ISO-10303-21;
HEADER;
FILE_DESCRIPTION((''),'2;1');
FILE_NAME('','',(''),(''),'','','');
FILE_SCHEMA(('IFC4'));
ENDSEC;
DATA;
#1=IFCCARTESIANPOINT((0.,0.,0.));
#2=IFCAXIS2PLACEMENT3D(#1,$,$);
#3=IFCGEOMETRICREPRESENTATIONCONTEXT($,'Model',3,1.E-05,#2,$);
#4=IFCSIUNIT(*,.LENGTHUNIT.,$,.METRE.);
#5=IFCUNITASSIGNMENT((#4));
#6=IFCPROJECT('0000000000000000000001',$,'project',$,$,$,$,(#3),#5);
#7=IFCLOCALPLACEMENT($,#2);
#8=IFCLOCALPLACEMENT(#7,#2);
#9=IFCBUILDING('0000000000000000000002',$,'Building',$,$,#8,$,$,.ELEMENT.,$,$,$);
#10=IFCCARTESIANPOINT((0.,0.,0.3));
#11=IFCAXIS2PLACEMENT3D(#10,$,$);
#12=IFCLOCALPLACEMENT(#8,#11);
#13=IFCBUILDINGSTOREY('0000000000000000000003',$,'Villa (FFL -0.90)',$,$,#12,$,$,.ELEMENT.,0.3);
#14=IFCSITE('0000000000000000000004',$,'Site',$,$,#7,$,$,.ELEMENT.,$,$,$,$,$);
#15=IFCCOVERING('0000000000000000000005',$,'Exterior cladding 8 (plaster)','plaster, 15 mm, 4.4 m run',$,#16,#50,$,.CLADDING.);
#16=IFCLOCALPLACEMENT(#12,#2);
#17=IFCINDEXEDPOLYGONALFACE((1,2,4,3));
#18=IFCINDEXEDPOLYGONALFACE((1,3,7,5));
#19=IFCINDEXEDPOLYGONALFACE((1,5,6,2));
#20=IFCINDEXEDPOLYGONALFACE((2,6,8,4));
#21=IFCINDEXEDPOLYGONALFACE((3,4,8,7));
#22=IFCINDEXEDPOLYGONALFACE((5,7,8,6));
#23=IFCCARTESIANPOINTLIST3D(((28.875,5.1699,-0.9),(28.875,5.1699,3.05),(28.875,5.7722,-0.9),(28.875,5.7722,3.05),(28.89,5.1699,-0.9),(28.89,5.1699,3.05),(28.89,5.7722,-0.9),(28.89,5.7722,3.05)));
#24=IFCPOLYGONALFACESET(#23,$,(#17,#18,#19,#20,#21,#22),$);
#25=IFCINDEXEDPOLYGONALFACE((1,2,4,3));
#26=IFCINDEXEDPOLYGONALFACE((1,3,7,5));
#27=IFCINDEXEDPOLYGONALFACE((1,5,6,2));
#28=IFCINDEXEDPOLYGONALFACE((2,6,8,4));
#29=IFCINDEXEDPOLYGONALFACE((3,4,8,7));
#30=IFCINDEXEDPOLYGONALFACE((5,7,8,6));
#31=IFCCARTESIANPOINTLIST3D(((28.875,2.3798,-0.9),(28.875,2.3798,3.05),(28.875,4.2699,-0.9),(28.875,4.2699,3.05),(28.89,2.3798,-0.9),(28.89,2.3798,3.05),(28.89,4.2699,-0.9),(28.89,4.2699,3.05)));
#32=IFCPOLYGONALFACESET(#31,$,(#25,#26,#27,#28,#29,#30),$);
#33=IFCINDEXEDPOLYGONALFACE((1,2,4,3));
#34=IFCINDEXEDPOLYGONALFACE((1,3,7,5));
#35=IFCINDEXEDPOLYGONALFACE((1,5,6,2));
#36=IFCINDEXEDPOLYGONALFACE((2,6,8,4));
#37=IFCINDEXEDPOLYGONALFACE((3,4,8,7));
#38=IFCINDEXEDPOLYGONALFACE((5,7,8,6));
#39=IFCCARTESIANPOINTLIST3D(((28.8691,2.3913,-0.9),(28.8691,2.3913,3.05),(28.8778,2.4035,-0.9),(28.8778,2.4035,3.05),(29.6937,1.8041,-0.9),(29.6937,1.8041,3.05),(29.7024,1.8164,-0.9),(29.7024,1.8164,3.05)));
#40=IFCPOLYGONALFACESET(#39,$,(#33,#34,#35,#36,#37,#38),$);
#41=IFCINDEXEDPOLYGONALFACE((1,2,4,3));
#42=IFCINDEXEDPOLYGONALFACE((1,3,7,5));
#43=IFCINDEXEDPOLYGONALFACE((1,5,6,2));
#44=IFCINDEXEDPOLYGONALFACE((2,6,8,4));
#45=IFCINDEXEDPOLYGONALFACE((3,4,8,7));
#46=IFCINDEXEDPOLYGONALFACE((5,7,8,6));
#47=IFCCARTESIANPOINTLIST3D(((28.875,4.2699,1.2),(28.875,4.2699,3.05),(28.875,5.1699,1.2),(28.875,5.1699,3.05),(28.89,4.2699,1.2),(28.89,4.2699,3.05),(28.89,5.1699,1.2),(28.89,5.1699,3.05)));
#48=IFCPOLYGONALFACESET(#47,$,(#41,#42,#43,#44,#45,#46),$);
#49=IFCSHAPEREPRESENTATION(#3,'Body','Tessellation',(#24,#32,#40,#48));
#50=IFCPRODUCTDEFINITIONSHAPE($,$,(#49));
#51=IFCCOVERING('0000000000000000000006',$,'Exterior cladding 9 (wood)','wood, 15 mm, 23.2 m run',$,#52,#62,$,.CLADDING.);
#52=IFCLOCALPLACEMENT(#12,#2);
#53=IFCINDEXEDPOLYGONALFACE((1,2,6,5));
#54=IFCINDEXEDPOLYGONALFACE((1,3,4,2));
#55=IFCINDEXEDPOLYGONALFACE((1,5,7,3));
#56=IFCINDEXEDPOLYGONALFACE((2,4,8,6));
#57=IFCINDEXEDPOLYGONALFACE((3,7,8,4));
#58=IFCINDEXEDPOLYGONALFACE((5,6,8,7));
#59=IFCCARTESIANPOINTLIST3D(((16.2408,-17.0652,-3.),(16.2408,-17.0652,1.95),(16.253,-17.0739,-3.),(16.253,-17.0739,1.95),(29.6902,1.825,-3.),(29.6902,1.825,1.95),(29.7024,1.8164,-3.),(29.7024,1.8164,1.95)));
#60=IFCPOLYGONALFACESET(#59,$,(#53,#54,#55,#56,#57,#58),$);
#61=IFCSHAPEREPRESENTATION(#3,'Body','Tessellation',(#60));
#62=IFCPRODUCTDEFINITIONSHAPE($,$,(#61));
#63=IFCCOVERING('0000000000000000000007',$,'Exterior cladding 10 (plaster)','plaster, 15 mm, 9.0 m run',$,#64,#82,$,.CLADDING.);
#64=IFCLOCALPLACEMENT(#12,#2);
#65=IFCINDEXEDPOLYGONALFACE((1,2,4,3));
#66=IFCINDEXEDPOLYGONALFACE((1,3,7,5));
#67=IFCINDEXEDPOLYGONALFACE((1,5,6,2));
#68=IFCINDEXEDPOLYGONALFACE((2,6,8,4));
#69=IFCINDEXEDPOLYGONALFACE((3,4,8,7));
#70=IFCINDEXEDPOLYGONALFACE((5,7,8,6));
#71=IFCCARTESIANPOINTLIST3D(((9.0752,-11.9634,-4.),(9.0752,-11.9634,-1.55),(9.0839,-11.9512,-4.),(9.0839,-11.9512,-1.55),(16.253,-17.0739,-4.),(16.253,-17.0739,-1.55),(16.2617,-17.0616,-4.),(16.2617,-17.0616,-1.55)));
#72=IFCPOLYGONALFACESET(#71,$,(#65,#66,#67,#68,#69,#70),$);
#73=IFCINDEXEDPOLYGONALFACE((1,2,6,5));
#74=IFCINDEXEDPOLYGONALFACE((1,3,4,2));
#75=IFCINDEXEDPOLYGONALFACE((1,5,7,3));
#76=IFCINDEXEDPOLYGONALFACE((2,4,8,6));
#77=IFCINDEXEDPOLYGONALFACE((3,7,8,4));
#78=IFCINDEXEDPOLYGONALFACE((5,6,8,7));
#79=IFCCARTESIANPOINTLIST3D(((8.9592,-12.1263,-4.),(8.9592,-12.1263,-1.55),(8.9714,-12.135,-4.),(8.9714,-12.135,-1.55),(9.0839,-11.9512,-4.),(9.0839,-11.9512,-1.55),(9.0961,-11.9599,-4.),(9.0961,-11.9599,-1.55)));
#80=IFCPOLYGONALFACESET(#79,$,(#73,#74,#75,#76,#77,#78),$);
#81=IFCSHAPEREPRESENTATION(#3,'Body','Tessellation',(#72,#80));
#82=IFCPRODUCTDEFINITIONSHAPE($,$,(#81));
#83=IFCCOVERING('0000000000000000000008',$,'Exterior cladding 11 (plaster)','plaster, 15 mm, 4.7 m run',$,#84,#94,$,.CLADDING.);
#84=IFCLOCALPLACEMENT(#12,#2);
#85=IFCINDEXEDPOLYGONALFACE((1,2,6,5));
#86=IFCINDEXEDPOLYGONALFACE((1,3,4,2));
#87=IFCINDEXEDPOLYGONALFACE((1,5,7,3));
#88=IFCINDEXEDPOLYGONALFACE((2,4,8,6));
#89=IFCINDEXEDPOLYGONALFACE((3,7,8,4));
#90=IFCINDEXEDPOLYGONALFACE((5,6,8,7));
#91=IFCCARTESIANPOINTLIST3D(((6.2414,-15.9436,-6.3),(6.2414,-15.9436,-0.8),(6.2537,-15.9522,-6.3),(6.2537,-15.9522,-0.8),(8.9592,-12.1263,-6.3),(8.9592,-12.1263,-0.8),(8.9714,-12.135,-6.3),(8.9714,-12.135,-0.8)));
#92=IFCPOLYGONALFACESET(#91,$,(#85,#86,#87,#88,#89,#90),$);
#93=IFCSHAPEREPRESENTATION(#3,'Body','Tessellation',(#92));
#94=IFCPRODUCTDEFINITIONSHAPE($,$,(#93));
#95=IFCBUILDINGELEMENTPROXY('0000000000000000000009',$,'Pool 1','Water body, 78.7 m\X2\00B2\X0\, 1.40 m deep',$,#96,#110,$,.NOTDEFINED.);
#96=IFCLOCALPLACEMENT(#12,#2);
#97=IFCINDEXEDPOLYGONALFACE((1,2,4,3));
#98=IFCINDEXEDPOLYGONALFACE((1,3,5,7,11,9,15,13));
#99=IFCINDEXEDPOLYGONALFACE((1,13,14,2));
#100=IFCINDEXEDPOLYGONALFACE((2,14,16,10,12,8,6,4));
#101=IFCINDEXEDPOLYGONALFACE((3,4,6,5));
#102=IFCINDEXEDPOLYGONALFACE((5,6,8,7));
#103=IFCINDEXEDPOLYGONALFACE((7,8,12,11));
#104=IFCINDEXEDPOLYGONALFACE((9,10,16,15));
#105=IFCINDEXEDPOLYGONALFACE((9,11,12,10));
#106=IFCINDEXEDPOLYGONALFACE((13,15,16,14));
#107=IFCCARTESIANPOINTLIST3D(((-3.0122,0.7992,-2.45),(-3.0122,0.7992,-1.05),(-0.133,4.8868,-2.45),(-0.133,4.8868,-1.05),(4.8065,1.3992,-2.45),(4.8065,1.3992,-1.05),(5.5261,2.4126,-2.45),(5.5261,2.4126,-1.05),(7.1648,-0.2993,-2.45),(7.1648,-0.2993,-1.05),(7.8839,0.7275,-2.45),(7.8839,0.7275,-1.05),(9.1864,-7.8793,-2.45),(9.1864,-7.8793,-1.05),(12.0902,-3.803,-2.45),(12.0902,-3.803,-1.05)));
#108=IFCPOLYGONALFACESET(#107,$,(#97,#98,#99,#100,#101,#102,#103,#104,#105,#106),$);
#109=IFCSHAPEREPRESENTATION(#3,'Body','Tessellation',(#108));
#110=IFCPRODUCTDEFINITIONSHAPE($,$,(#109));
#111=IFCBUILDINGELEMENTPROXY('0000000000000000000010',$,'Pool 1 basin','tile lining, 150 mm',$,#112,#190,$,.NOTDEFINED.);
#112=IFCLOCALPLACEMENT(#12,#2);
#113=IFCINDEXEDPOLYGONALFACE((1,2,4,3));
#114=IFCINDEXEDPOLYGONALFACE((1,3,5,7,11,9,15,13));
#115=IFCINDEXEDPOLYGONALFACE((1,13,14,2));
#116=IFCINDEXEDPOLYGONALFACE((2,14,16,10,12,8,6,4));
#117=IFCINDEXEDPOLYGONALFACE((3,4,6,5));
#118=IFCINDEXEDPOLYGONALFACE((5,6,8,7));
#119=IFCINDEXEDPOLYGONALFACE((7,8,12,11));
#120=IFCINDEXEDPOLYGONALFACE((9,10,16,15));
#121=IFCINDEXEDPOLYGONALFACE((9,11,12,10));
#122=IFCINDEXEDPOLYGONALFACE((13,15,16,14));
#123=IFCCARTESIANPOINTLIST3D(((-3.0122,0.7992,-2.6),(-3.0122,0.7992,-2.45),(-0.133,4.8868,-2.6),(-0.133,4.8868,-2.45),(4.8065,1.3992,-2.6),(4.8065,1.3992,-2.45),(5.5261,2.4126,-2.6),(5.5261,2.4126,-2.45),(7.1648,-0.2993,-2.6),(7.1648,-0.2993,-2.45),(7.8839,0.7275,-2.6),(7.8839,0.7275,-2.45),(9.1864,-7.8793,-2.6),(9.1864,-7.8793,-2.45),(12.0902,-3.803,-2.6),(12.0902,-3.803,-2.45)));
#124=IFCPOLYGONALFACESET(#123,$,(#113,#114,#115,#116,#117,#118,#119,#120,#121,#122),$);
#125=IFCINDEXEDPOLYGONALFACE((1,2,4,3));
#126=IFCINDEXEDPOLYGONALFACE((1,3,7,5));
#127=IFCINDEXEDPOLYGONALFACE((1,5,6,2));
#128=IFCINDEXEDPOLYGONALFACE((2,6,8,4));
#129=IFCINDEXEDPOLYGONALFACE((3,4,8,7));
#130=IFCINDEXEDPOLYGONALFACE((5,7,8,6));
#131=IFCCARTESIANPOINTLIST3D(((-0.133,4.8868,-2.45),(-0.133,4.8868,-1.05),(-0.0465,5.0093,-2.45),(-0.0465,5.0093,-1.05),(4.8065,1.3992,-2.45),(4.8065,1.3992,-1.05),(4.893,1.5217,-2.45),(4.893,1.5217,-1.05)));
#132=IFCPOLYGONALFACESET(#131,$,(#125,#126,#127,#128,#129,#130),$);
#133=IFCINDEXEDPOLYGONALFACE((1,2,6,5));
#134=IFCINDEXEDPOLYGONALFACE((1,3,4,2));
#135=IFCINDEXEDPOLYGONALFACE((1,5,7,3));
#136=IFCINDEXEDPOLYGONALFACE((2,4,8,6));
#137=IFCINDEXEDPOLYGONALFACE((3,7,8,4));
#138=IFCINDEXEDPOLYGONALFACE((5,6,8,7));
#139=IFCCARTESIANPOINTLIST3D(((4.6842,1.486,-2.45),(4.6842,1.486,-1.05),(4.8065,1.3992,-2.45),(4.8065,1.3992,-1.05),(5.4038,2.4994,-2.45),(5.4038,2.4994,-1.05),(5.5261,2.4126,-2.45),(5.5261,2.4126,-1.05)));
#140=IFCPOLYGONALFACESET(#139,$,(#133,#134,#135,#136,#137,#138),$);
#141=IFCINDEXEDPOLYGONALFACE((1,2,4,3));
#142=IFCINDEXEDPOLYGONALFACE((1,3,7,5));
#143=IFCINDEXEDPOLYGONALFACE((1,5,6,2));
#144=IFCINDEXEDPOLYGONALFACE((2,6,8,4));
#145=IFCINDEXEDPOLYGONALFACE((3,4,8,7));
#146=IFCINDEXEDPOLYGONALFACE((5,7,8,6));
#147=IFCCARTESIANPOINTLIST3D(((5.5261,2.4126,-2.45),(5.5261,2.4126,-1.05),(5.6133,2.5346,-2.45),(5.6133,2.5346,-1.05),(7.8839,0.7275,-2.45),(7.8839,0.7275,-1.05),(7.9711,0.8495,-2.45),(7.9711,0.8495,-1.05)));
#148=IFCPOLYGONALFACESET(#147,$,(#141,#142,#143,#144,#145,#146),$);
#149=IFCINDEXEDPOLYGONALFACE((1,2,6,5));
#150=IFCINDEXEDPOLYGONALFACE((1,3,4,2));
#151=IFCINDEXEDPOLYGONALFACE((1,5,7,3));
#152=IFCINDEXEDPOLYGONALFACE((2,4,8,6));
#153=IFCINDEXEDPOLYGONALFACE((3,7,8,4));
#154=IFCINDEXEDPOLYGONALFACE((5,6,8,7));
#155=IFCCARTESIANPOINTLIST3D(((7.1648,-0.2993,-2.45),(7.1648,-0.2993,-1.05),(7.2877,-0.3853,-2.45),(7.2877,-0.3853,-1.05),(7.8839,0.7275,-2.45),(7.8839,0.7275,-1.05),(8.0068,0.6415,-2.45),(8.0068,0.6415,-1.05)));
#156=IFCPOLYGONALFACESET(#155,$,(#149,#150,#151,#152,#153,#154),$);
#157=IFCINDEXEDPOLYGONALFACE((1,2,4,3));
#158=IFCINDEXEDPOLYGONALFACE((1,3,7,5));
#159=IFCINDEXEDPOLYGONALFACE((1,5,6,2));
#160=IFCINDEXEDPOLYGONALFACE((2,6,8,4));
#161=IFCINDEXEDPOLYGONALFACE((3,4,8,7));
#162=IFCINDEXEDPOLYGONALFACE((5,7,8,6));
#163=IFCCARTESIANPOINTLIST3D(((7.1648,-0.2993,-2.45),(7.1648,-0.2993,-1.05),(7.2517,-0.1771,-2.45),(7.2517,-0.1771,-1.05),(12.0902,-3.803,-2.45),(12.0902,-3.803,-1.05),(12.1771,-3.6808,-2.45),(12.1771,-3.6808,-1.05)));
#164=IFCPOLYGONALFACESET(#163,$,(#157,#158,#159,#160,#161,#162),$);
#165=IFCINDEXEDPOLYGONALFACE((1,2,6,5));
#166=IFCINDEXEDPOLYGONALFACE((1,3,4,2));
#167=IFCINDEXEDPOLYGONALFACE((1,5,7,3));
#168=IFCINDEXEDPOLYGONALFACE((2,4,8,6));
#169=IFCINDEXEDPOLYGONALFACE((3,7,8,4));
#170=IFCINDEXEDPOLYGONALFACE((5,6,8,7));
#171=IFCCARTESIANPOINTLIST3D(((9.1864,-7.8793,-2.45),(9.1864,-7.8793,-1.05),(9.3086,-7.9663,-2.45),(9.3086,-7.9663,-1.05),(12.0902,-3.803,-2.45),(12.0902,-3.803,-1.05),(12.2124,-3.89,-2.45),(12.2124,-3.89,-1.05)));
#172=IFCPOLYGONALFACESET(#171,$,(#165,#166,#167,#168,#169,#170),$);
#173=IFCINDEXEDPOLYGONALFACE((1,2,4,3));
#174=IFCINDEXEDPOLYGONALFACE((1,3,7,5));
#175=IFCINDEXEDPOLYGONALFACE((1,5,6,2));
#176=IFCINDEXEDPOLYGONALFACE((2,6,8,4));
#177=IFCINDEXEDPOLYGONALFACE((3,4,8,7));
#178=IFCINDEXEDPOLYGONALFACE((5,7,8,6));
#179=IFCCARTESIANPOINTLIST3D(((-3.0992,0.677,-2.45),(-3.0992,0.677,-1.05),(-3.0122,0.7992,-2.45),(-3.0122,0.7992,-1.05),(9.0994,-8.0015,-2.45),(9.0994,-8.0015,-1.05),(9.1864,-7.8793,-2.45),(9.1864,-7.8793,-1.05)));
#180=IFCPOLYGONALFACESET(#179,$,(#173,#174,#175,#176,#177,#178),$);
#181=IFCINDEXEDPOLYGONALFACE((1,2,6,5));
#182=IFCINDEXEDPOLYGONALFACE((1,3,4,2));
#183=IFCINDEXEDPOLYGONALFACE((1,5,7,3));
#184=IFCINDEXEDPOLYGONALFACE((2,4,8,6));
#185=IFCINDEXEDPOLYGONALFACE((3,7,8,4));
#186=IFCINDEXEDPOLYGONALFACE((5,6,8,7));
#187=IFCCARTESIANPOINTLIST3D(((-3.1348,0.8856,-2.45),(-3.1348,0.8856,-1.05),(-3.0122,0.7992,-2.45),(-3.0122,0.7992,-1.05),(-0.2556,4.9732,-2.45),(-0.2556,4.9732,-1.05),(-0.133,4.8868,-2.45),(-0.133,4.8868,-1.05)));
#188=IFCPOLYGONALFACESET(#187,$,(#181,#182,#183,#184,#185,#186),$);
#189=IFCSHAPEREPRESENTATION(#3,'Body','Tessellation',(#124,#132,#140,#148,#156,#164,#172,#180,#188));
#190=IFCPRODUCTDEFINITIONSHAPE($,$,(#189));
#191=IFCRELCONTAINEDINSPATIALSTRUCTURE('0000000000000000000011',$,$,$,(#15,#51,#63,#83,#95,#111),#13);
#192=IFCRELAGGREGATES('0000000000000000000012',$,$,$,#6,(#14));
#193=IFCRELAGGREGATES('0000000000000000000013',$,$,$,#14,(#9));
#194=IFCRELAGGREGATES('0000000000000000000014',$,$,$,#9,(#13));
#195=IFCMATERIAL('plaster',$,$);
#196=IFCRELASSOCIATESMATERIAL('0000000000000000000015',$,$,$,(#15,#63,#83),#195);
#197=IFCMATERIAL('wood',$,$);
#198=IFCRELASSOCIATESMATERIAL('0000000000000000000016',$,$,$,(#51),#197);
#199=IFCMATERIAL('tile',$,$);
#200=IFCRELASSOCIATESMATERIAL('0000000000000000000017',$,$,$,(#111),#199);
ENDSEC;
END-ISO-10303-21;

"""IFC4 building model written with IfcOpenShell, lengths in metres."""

from ifc_helpers import new_model, si_unit, frame, origin, origin_with_axes, place, context, project, spatial, polyline, outline, extrude, material, element, save


model = new_model("IFC4")

# Units and contexts
model_context = context("Model", 3, precision=1e-05, world=origin())
ifc_project = project(units=[si_unit("LENGTHUNIT", "METRE")], contexts=[model_context])

# Site, building, storey
site_placement = place(None, origin())
site = spatial("IfcSite", under=ifc_project, at=site_placement, Name="Site", CompositionType="ELEMENT")
building_placement = place(site_placement, origin())
building = spatial("IfcBuilding", under=site, at=building_placement, Name="Building", CompositionType="ELEMENT")
storey_placement = place(building_placement, frame((0.0, 0.0, 0.3)))
storey = spatial("IfcBuildingStorey", under=building, at=storey_placement, Name="Villa (FFL -0.90)", CompositionType="ELEMENT", Elevation=0.3)

# Coverings
ifc_material_1 = material(Name="plaster")
covering_1_placement = place(storey_placement, origin_with_axes())
element("IfcCovering", 1, at=covering_1_placement, inside=storey, material=ifc_material_1, Name="Exterior cladding 8 (plaster)", Description="plaster, 15 mm, 4.4 m run", PredefinedType="CLADDING", context=model_context, shape_type="SweptSolid", body=[
    extrude(outline(polyline([(28.875, 5.7721), (28.875, 5.1699), (28.89, 5.1699), (28.89, 5.7721), (28.875, 5.7721)])), frame((0.0, 0.0, -0.9)), (0.0, 0.0, 1.0), 3.95),
    extrude(outline(polyline([(28.875, 4.2699), (28.875, 2.3798), (28.89, 2.3798), (28.89, 4.2699), (28.875, 4.2699)])), frame((0.0, 0.0, -0.9)), (0.0, 0.0, 1.0), 3.95),
    extrude(outline(polyline([(28.8691, 2.3913), (29.6937, 1.8041), (29.7024, 1.8163), (28.8778, 2.4035), (28.8691, 2.3913)])), frame((0.0, 0.0, -0.9)), (0.0, 0.0, 1.0), 3.95),
    extrude(outline(polyline([(28.875, 5.1699), (28.875, 4.2699), (28.89, 4.2699), (28.89, 5.1699), (28.875, 5.1699)])), frame((0.0, 0.0, 1.2)), (0.0, 0.0, 1.0), 1.85),
])
ifc_material_2 = material(Name="wood")
covering_2_placement = place(storey_placement, origin_with_axes())
element("IfcCovering", 2, at=covering_2_placement, inside=storey, material=ifc_material_2, Name="Exterior cladding 9 (wood)", Description="wood, 15 mm, 23.2 m run", PredefinedType="CLADDING", context=model_context, shape_type="SweptSolid", body=[
    extrude(outline(polyline([(29.6902, 1.8251), (16.2408, -17.0652), (16.253, -17.0739), (29.7024, 1.8163), (29.6902, 1.8251)])), frame((0.0, 0.0, -3.0)), (0.0, 0.0, 1.0), 4.95),
])
covering_3_placement = place(storey_placement, origin_with_axes())
element("IfcCovering", 3, at=covering_3_placement, inside=storey, material=ifc_material_1, Name="Exterior cladding 10 (plaster)", Description="plaster, 15 mm, 9.0 m run", PredefinedType="CLADDING", context=model_context, shape_type="SweptSolid", body=[
    extrude(outline(polyline([(16.2617, -17.0616), (9.0839, -11.9512), (9.0752, -11.9634), (16.253, -17.0739), (16.2617, -17.0616)])), frame((0.0, 0.0, -4.0)), (0.0, 0.0, 1.0), 2.45),
    extrude(outline(polyline([(9.0839, -11.9512), (8.9592, -12.1263), (8.9714, -12.135), (9.0961, -11.9599), (9.0839, -11.9512)])), frame((0.0, 0.0, -4.0)), (0.0, 0.0, 1.0), 2.45),
])
covering_4_placement = place(storey_placement, origin_with_axes())
element("IfcCovering", 4, at=covering_4_placement, inside=storey, material=ifc_material_1, Name="Exterior cladding 11 (plaster)", Description="plaster, 15 mm, 4.7 m run", PredefinedType="CLADDING", context=model_context, shape_type="SweptSolid", body=[
    extrude(outline(polyline([(8.9592, -12.1263), (6.2414, -15.9436), (6.2537, -15.9522), (8.9714, -12.135), (8.9592, -12.1263)])), frame((0.0, 0.0, -6.3)), (0.0, 0.0, 1.0), 5.5),
])

# Building element proxies
placement = place(storey_placement, origin_with_axes())
element("IfcBuildingElementProxy", 5, at=placement, inside=storey, Name="Pool 1", Description="Water body, 78.7 m², 1.40 m deep", PredefinedType="NOTDEFINED", context=model_context, shape_type="SweptSolid", body=[
    extrude(outline(polyline([(-0.133, 4.8868), (4.8065, 1.3992), (5.5261, 2.4126), (7.8839, 0.7275), (7.1648, -0.2993), (12.0902, -3.803), (9.1864, -7.8793), (-3.0122, 0.7992), (-0.133, 4.8868)])), frame((0.0, 0.0, -2.45)), (0.0, 0.0, 1.0), 1.4),
])
ifc_material_3 = material(Name="tile")
element("IfcBuildingElementProxy", 6, at=placement, inside=storey, material=ifc_material_3, Name="Pool 1 basin", Description="tile lining, 150 mm", PredefinedType="NOTDEFINED", context=model_context, shape_type="SweptSolid", body=[
    extrude(outline(polyline([(-0.133, 4.8868), (4.8065, 1.3992), (5.5261, 2.4126), (7.8839, 0.7275), (7.1648, -0.2993), (12.0902, -3.803), (9.1864, -7.8793), (-3.0122, 0.7992), (-0.133, 4.8868)])), frame((0.0, 0.0, -2.6)), (0.0, 0.0, 1.0), 0.15),
    extrude(outline(polyline([(-0.133, 4.8868), (4.8065, 1.3992), (4.893, 1.5217), (-0.0465, 5.0093), (-0.133, 4.8868)])), frame((0.0, 0.0, -2.45)), (0.0, 0.0, 1.0), 1.4),
    extrude(outline(polyline([(4.8065, 1.3992), (5.5261, 2.4126), (5.4038, 2.4994), (4.6842, 1.486), (4.8065, 1.3992)])), frame((0.0, 0.0, -2.45)), (0.0, 0.0, 1.0), 1.4),
    extrude(outline(polyline([(5.5261, 2.4126), (7.8839, 0.7275), (7.9711, 0.8495), (5.6133, 2.5346), (5.5261, 2.4126)])), frame((0.0, 0.0, -2.45)), (0.0, 0.0, 1.0), 1.4),
    extrude(outline(polyline([(7.8839, 0.7275), (7.1648, -0.2993), (7.2877, -0.3853), (8.0068, 0.6415), (7.8839, 0.7275)])), frame((0.0, 0.0, -2.45)), (0.0, 0.0, 1.0), 1.4),
    extrude(outline(polyline([(7.1648, -0.2993), (12.0902, -3.803), (12.1771, -3.6808), (7.2517, -0.1771), (7.1648, -0.2993)])), frame((0.0, 0.0, -2.45)), (0.0, 0.0, 1.0), 1.4),
    extrude(outline(polyline([(12.0902, -3.803), (9.1864, -7.8793), (9.3086, -7.9663), (12.2124, -3.89), (12.0902, -3.803)])), frame((0.0, 0.0, -2.45)), (0.0, 0.0, 1.0), 1.4),
    extrude(outline(polyline([(9.1864, -7.8793), (-3.0122, 0.7992), (-3.0992, 0.677), (9.0994, -8.0015), (9.1864, -7.8793)])), frame((0.0, 0.0, -2.45)), (0.0, 0.0, 1.0), 1.4),
    extrude(outline(polyline([(-3.0122, 0.7992), (-0.133, 4.8868), (-0.2556, 4.9732), (-3.1348, 0.8856), (-3.0122, 0.7992)])), frame((0.0, 0.0, -2.45)), (0.0, 0.0, 1.0), 1.4),
])

save(model, "model.ifc")
